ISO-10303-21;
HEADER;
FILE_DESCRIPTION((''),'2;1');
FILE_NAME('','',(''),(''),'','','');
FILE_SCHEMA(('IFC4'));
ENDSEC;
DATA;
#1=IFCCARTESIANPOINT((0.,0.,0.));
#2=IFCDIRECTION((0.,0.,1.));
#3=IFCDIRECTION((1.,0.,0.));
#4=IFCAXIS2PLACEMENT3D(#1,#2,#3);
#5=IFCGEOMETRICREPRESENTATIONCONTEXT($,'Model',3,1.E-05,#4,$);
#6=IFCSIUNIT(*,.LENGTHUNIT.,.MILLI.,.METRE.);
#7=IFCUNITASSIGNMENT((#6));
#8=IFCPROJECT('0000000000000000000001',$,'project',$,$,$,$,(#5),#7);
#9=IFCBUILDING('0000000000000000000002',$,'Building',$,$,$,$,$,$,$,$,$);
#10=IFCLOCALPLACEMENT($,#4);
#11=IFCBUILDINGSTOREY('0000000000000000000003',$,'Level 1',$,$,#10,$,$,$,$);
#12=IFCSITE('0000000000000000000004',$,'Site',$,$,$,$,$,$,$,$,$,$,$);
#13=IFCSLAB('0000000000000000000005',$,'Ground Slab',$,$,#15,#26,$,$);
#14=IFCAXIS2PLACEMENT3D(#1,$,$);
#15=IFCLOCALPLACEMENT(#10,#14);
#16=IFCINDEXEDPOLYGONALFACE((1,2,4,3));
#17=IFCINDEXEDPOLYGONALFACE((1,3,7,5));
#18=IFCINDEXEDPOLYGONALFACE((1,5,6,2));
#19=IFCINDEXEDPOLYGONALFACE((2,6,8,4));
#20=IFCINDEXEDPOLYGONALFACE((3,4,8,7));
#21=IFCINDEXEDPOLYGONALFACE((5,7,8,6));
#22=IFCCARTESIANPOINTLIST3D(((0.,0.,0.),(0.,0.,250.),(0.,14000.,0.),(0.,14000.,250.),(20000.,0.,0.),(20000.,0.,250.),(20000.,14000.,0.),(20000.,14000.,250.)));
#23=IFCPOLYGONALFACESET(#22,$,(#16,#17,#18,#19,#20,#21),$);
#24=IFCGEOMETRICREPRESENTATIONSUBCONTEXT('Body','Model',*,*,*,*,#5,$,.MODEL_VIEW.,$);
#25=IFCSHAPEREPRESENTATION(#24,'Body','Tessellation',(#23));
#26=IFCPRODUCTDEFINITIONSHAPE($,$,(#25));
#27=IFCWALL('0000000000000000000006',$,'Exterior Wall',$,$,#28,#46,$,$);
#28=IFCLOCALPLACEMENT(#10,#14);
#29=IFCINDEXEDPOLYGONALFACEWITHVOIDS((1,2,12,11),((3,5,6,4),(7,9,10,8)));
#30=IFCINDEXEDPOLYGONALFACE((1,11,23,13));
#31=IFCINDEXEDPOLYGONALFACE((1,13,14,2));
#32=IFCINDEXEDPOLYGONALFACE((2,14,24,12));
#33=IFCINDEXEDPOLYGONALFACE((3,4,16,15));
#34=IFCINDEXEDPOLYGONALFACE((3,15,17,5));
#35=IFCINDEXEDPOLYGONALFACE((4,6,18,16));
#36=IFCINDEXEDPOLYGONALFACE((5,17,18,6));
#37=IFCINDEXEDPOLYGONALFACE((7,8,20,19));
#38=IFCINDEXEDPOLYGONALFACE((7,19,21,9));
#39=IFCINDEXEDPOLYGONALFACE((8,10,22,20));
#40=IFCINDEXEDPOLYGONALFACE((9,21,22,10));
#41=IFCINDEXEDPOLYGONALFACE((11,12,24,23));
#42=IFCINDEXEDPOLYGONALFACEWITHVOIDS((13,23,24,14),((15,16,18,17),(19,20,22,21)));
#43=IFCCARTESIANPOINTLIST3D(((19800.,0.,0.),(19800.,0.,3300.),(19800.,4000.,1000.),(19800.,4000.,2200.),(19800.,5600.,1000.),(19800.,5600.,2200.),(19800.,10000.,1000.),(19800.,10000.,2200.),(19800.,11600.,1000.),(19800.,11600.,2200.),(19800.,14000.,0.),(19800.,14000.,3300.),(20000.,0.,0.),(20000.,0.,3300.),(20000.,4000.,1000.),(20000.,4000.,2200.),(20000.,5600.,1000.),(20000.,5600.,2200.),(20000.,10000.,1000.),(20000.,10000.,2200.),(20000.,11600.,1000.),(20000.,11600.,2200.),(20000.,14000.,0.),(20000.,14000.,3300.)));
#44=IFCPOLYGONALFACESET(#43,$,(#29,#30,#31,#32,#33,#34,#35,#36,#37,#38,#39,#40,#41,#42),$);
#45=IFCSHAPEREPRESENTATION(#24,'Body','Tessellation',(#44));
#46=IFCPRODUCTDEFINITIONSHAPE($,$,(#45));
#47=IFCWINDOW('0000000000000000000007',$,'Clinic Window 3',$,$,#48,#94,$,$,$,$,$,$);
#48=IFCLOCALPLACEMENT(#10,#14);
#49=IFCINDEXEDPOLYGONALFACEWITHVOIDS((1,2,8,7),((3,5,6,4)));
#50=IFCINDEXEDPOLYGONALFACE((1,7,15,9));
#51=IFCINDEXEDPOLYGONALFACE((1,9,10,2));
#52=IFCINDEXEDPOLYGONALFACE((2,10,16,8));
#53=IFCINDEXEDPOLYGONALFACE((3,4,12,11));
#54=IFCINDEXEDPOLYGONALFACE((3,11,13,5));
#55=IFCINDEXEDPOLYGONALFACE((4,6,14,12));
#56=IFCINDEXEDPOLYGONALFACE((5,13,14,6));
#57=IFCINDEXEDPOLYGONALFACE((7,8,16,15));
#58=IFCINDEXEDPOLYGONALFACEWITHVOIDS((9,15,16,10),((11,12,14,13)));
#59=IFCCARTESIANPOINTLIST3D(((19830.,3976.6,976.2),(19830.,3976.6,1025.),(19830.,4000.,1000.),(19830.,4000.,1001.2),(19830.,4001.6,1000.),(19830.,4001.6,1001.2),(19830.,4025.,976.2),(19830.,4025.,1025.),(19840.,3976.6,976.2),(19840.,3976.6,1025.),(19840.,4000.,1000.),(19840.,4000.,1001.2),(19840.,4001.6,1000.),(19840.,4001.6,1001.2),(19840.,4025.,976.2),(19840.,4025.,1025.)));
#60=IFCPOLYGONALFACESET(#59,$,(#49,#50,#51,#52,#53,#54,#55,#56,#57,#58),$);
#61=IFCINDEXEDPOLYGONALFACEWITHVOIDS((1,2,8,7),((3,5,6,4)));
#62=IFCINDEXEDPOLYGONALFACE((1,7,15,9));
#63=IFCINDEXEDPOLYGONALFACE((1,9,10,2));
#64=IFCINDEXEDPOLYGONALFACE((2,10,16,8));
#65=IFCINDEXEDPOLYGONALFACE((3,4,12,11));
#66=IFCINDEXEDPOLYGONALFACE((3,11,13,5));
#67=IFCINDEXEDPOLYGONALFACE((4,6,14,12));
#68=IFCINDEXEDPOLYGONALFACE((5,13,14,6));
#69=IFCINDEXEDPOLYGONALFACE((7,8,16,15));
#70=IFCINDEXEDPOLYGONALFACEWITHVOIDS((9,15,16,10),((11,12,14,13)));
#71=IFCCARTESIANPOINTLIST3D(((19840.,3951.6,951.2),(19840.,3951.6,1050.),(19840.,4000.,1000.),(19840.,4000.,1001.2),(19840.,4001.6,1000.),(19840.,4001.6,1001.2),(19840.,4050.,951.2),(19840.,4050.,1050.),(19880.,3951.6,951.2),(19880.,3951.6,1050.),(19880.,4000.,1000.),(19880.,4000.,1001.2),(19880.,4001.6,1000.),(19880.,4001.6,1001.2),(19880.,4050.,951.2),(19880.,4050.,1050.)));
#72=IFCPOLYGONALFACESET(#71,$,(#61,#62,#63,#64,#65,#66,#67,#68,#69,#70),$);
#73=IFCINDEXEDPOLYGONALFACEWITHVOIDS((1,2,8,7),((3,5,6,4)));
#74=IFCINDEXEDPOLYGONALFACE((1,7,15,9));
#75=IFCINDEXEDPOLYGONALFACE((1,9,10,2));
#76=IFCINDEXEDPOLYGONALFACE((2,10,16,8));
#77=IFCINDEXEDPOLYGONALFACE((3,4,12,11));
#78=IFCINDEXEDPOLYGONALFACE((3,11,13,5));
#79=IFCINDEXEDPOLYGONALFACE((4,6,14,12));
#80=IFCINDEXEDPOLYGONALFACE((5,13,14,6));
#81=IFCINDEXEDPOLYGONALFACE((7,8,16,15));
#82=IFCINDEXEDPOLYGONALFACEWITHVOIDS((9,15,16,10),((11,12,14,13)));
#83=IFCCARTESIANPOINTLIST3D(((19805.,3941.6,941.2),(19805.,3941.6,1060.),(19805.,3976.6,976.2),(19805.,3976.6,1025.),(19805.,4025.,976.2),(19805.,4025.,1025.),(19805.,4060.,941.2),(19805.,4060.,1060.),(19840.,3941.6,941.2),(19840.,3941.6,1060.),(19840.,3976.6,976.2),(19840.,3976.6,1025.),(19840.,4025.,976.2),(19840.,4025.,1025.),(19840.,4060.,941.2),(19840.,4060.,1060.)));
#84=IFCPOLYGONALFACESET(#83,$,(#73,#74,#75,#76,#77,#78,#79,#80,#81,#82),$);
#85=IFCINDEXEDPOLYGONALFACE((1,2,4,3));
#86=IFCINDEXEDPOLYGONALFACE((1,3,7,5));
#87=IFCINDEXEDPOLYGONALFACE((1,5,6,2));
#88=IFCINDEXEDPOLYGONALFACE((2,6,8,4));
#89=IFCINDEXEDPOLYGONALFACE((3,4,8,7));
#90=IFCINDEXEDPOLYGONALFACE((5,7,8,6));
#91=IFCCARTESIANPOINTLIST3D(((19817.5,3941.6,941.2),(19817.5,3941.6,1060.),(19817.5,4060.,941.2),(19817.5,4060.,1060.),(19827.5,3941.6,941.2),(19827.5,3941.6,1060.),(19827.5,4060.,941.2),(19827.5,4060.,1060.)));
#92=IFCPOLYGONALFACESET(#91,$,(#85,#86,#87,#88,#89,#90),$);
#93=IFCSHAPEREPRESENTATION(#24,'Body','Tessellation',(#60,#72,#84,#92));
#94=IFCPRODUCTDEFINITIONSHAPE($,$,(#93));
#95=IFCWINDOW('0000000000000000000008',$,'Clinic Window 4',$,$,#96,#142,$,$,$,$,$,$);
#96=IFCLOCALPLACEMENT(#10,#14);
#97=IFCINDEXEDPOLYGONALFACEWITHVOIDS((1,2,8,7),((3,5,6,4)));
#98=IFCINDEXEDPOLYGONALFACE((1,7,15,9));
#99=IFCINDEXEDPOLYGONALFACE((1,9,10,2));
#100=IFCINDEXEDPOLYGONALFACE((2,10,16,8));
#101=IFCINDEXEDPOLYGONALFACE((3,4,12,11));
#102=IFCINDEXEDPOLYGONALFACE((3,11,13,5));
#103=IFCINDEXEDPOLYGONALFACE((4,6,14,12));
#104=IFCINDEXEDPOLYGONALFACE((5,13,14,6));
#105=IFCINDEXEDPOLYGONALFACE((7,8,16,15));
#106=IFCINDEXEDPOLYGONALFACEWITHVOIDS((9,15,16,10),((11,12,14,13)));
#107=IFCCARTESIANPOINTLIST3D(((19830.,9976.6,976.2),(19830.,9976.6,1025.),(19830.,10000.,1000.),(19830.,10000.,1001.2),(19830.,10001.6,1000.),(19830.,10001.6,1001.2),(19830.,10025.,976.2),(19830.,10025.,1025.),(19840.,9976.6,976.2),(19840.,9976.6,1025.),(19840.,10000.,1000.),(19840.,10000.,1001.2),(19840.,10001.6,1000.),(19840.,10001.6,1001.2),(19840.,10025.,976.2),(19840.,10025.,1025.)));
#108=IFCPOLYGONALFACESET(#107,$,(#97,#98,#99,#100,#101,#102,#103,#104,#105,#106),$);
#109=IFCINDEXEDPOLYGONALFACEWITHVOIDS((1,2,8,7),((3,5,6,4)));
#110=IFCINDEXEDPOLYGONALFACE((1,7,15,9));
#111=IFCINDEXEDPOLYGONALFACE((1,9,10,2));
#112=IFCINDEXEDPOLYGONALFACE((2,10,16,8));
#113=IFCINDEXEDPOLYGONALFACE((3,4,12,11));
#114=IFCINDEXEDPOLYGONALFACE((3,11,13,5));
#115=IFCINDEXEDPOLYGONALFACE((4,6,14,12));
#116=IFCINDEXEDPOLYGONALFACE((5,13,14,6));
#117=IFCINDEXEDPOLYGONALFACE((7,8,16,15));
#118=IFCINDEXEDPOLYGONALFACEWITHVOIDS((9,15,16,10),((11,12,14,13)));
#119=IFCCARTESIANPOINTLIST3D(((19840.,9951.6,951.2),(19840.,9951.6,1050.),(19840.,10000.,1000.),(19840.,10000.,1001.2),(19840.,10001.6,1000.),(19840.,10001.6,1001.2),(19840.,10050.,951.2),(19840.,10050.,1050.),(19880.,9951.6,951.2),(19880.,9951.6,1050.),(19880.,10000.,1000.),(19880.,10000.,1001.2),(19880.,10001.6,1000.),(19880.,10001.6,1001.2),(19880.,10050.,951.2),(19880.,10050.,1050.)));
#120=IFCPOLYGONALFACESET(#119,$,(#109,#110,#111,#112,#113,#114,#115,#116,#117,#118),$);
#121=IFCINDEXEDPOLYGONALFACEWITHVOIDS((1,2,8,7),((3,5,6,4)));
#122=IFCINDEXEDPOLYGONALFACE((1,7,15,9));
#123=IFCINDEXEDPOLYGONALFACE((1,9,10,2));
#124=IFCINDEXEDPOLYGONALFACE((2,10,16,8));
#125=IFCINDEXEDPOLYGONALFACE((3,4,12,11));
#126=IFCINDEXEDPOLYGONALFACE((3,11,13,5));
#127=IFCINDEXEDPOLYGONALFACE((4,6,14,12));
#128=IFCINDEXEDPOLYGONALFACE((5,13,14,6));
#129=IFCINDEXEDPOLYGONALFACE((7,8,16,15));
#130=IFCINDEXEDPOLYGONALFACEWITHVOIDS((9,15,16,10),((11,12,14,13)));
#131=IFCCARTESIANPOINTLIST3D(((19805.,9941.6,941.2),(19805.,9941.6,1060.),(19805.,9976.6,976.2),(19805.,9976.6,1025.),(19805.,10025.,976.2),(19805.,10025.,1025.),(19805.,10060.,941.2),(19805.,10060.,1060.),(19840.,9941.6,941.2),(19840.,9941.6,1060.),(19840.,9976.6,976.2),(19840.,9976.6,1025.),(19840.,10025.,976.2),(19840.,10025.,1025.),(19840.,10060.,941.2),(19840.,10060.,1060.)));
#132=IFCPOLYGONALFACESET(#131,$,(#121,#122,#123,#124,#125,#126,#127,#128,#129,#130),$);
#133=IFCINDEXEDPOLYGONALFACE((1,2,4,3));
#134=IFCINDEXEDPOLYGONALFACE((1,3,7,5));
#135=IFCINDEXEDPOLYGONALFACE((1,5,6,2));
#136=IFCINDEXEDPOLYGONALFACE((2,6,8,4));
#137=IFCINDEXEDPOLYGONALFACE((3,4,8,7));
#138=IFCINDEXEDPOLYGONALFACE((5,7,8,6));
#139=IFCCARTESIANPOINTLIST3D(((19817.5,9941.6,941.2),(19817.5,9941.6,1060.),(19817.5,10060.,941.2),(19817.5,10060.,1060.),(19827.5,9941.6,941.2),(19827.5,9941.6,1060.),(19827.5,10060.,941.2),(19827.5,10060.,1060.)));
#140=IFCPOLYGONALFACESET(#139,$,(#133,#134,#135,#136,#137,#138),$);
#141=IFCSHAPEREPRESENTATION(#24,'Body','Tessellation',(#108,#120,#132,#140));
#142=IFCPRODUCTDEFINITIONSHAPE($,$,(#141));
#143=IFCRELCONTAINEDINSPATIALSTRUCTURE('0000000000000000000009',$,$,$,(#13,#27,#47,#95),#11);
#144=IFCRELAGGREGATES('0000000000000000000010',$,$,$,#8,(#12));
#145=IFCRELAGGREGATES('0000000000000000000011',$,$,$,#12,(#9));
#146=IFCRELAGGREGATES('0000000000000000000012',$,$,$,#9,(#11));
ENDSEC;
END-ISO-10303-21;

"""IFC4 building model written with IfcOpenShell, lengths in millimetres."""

from ifc_helpers import new_model, si_unit, frame, origin_with_axes, place, context, subcontext, project, spatial, line, indexed_curve, outline, extrude, element, fill, save


model = new_model("IFC4")

# Units and contexts
model_context = context("Model", 3, precision=1e-05, world=origin_with_axes())
body_context = subcontext(model_context, "Body", "Model", "MODEL_VIEW")
ifc_project = project(units=[si_unit("LENGTHUNIT", "METRE", prefix="MILLI")], contexts=[model_context])

# Site, building, storey
site = spatial("IfcSite", under=ifc_project, Name="Site")
building = spatial("IfcBuilding", under=site, Name="Building")
storey_placement = place(None, origin_with_axes())
storey = spatial("IfcBuildingStorey", under=building, at=storey_placement, Name="Level 1")

# Slab
slab_placement = place(storey_placement, origin_with_axes())
element("IfcSlab", 1, at=slab_placement, inside=storey, Name="Ground Slab", context=body_context, shape_type="SweptSolid", body=[
    extrude(outline(indexed_curve([(0.0, 0.0), (20000.0, 0.0), (20000.0, 14000.0), (0.0, 14000.0), (0.0, 0.0)])), None, (0.0, 0.0, 1.0), 250.0),
])

# Wall, openings, windows
wall_1_placement = place(storey_placement, frame((20000.0, 0.0, 0.0), z_axis=(0.0, 0.0, 1.0), x_axis=(0.0, 1.0, 0.0)))
wall_1 = element("IfcWall", 2, at=wall_1_placement, inside=storey, Name="Exterior Wall", context=body_context, shape_type="SweptSolid", body=[
    extrude(outline(indexed_curve([(0.0, 0.0), (0.0, 200.0), (14000.0, 200.0), (14000.0, 0.0), (0.0, 0.0)], self_intersect=False)), origin_with_axes(), (0.0, 0.0, 1.0), 3300.0),
])
opening_1_placement = place(wall_1_placement, frame((4000.0, -100.0, 1000.0), z_axis=(0.0, 0.0, 1.0), x_axis=(1.0, 0.0, 0.0)))
opening_1 = element("IfcOpeningElement", 3, at=opening_1_placement, cuts=wall_1, context=body_context, shape_type="SweptSolid", body=[
    extrude(outline(indexed_curve([(0.0, 0.0), (0.0, 400.0), (1600.0, 400.0), (1600.0, 0.0), (0.0, 0.0)], self_intersect=False)), origin_with_axes(), (0.0, 0.0, 1.0), 1200.0),
])
opening_2_placement = place(wall_1_placement, frame((10000.0, -100.0, 1000.0), z_axis=(0.0, 0.0, 1.0), x_axis=(1.0, 0.0, 0.0)))
opening_2 = element("IfcOpeningElement", 4, at=opening_2_placement, cuts=wall_1, context=body_context, shape_type="SweptSolid", body=[
    extrude(outline(indexed_curve([(0.0, 0.0), (0.0, 400.0), (1600.0, 400.0), (1600.0, 0.0), (0.0, 0.0)], self_intersect=False)), origin_with_axes(), (0.0, 0.0, 1.0), 1200.0),
])
window_1_placement = place(opening_1_placement, frame((0.0, 170.0, 0.0), z_axis=(0.0, 0.0, 1.0), x_axis=(1.0, 0.0, 0.0)))
window_1 = element("IfcWindow", 5, at=window_1_placement, inside=storey, Name="Clinic Window 3", context=body_context, shape_type="SweptSolid", body=[
    extrude(outline(indexed_curve([(0.0, 0.0), (1.6, 0.0), (1.6, 1.2), (0.0, 1.2)], segments=[line(1, 2, 3, 4, 1)]), holes=[indexed_curve([(25.0, 25.0), (-23.4, 25.0), (-23.4, -23.8), (25.0, -23.8)], segments=[line(1, 2, 3, 4, 1)])]), frame((0.0, 90.0, 0.0), z_axis=(0.0, -1.0, 0.0), x_axis=(1.0, 0.0, 0.0)), (0.0, 0.0, -1.0), 10.0),
    extrude(outline(indexed_curve([(0.0, 0.0), (1.6, 0.0), (1.6, 1.2), (0.0, 1.2)], segments=[line(1, 2, 3, 4, 1)]), holes=[indexed_curve([(50.0, 50.0), (-48.4, 50.0), (-48.4, -48.8), (50.0, -48.8)], segments=[line(1, 2, 3, 4, 1)])]), frame((0.0, 50.0, 0.0), z_axis=(0.0, -1.0, 0.0), x_axis=(1.0, 0.0, 0.0)), (0.0, 0.0, -1.0), 40.0),
    extrude(outline(indexed_curve([(0.0, 0.0), (-48.4, 0.0), (-48.4, -48.8), (0.0, -48.8)], segments=[line(1, 2, 3, 4, 1)]), holes=[indexed_curve([(35.0, 35.0), (-83.4, 35.0), (-83.4, -83.8), (35.0, -83.8)], segments=[line(1, 2, 3, 4, 1)])]), frame((25.0, 90.0, 25.0), z_axis=(0.0, -1.0, 0.0), x_axis=(1.0, 0.0, 0.0)), (0.0, 0.0, -1.0), 35.0),
    extrude(outline(indexed_curve([(35.0, 35.0), (-83.4, 35.0), (-83.4, -83.8), (35.0, -83.8)], segments=[line(1, 2, 3, 4, 1)])), frame((25.0, 102.5, 25.0), z_axis=(0.0, -1.0, 0.0), x_axis=(1.0, 0.0, 0.0)), (0.0, 0.0, -1.0), 10.0),
])
fill(opening_1, window_1)
window_2_placement = place(opening_2_placement, frame((0.0, 170.0, 0.0), z_axis=(0.0, 0.0, 1.0), x_axis=(1.0, 0.0, 0.0)))
window_2 = element("IfcWindow", 6, at=window_2_placement, inside=storey, Name="Clinic Window 4", context=body_context, shape_type="SweptSolid", body=[
    extrude(outline(indexed_curve([(0.0, 0.0), (1.6, 0.0), (1.6, 1.2), (0.0, 1.2)], segments=[line(1, 2, 3, 4, 1)]), holes=[indexed_curve([(25.0, 25.0), (-23.4, 25.0), (-23.4, -23.8), (25.0, -23.8)], segments=[line(1, 2, 3, 4, 1)])]), frame((0.0, 90.0, 0.0), z_axis=(0.0, -1.0, 0.0), x_axis=(1.0, 0.0, 0.0)), (0.0, 0.0, -1.0), 10.0),
    extrude(outline(indexed_curve([(0.0, 0.0), (1.6, 0.0), (1.6, 1.2), (0.0, 1.2)], segments=[line(1, 2, 3, 4, 1)]), holes=[indexed_curve([(50.0, 50.0), (-48.4, 50.0), (-48.4, -48.8), (50.0, -48.8)], segments=[line(1, 2, 3, 4, 1)])]), frame((0.0, 50.0, 0.0), z_axis=(0.0, -1.0, 0.0), x_axis=(1.0, 0.0, 0.0)), (0.0, 0.0, -1.0), 40.0),
    extrude(outline(indexed_curve([(0.0, 0.0), (-48.4, 0.0), (-48.4, -48.8), (0.0, -48.8)], segments=[line(1, 2, 3, 4, 1)]), holes=[indexed_curve([(35.0, 35.0), (-83.4, 35.0), (-83.4, -83.8), (35.0, -83.8)], segments=[line(1, 2, 3, 4, 1)])]), frame((25.0, 90.0, 25.0), z_axis=(0.0, -1.0, 0.0), x_axis=(1.0, 0.0, 0.0)), (0.0, 0.0, -1.0), 35.0),
    extrude(outline(indexed_curve([(35.0, 35.0), (-83.4, 35.0), (-83.4, -83.8), (35.0, -83.8)], segments=[line(1, 2, 3, 4, 1)])), frame((25.0, 102.5, 25.0), z_axis=(0.0, -1.0, 0.0), x_axis=(1.0, 0.0, 0.0)), (0.0, 0.0, -1.0), 10.0),
])
fill(opening_2, window_2)

save(model, "model.ifc")
